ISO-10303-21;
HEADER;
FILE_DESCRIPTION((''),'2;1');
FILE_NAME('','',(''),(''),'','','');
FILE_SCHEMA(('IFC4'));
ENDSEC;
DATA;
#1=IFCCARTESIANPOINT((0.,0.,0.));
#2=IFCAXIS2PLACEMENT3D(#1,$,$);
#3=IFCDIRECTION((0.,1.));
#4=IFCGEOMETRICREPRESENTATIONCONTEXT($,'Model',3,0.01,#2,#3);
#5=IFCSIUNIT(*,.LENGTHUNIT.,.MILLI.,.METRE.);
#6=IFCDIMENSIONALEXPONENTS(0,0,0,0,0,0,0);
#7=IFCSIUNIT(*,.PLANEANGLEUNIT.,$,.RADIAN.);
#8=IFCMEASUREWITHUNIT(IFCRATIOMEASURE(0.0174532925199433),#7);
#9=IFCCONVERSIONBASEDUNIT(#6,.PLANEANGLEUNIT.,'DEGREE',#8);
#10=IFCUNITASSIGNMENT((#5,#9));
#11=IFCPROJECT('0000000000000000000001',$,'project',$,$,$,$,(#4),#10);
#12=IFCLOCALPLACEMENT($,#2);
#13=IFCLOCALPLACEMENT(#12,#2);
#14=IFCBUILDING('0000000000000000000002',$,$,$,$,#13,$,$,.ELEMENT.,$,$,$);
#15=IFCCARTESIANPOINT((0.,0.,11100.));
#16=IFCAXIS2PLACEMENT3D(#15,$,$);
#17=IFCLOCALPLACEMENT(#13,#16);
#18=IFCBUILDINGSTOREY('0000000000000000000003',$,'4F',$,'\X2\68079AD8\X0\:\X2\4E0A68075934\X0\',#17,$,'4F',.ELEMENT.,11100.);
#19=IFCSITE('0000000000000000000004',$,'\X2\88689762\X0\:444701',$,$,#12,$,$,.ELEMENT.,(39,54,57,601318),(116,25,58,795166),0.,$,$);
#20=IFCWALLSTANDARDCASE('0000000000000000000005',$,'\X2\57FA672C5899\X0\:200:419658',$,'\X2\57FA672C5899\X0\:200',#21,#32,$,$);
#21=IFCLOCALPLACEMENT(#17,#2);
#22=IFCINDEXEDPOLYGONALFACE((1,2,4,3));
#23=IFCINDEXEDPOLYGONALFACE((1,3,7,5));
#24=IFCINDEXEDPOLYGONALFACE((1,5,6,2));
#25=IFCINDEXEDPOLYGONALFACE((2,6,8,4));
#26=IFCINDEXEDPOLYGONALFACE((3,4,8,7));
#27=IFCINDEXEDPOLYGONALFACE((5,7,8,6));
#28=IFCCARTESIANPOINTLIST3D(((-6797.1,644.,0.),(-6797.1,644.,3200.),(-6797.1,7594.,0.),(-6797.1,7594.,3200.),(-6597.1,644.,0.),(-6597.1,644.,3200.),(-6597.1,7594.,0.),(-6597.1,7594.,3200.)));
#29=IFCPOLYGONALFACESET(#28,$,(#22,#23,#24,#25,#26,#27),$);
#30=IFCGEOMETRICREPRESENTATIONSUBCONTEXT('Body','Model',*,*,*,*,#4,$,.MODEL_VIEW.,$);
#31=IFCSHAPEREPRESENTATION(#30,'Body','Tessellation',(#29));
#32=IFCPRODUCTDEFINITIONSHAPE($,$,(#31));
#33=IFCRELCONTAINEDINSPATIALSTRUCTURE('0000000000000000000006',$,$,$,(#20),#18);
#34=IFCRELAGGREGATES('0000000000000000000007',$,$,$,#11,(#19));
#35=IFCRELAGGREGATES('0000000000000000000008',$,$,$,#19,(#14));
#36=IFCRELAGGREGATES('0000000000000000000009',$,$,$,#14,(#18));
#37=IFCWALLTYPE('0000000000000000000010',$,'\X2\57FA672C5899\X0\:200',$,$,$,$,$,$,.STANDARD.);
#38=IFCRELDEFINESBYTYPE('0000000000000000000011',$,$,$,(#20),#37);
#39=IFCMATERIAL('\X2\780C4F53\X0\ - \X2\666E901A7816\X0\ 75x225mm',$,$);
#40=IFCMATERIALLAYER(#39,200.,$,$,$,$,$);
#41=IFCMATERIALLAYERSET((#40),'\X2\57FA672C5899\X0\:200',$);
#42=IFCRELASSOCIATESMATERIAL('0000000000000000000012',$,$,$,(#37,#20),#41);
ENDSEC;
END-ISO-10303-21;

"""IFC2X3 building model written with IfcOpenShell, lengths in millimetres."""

from ifc_helpers import new_model, entity, si_unit, converted_unit, direction, frame, frame_2d, origin, place, context, subcontext, project, spatial, rectangle, extrude, material, layer, layer_set, layer_usage, type_object, element, save


model = new_model("IFC2X3")

# Units and contexts
model_context = context("Model", 3, precision=0.01, world=origin(), true_north=direction((0.0, 1.0)))
body_context = subcontext(model_context, "Body", "Model", "MODEL_VIEW")
ifc_project = project(units=[si_unit("LENGTHUNIT", "METRE", prefix="MILLI"), converted_unit("PLANEANGLEUNIT", "DEGREE", entity("IfcRatioMeasure", 0.0174532925199433), si_unit("PLANEANGLEUNIT", "RADIAN"), dimensions=[0, 0, 0, 0, 0, 0, 0])], contexts=[model_context])

# Site, building, storey
site_placement = place(None, origin())
site = spatial("IfcSite", under=ifc_project, at=site_placement, Name="表面:444701", CompositionType="ELEMENT", RefLatitude=(39, 54, 57, 601318), RefLongitude=(116, 25, 58, 795166), RefElevation=0.0)
building_placement = place(site_placement, origin())
building = spatial("IfcBuilding", under=site, at=building_placement, CompositionType="ELEMENT")
storey_placement = place(building_placement, frame((0.0, 0.0, 11100.0)))
storey = spatial("IfcBuildingStorey", under=building, at=storey_placement, Name="4F", ObjectType="标高:上标头", LongName="4F", CompositionType="ELEMENT", Elevation=11100.0)

# Shared definitions
ifc_material_1 = material(Name="砌体 - 普通砖 75x225mm")

# Shared definitions
ifc_layer_1 = layer(ifc_material_1, 200.0)
ifc_layer_set_1 = layer_set([ifc_layer_1], Name="基本墙:200")
wall_type_1 = type_object("IfcWallType", Name="基本墙:200", PredefinedType="STANDARD", material=ifc_layer_set_1)

# Wall
ifc_layer_usage_1 = layer_usage(ifc_layer_set_1, "AXIS2", "NEGATIVE", 100.0)
wall_1_placement = place(storey_placement, frame((-6697.1, 7594.0, 0.0), z_axis=(0.0, 0.0, 1.0), x_axis=(0.0, -1.0, 0.0)))
element("IfcWallStandardCase", 1, at=wall_1_placement, inside=storey, type_object=wall_type_1, material=ifc_layer_usage_1, Name="基本墙:200:419658", ObjectType="基本墙:200", context=body_context, shape_type="SweptSolid", body=[
    extrude(rectangle(XDim=6950.0, YDim=200.0, at=frame_2d((3475.0, 0.0), x_axis=(-1.0, 0.0))), origin(), (0.0, 0.0, 1.0), 3200.0),
])

save(model, "model.ifc")
